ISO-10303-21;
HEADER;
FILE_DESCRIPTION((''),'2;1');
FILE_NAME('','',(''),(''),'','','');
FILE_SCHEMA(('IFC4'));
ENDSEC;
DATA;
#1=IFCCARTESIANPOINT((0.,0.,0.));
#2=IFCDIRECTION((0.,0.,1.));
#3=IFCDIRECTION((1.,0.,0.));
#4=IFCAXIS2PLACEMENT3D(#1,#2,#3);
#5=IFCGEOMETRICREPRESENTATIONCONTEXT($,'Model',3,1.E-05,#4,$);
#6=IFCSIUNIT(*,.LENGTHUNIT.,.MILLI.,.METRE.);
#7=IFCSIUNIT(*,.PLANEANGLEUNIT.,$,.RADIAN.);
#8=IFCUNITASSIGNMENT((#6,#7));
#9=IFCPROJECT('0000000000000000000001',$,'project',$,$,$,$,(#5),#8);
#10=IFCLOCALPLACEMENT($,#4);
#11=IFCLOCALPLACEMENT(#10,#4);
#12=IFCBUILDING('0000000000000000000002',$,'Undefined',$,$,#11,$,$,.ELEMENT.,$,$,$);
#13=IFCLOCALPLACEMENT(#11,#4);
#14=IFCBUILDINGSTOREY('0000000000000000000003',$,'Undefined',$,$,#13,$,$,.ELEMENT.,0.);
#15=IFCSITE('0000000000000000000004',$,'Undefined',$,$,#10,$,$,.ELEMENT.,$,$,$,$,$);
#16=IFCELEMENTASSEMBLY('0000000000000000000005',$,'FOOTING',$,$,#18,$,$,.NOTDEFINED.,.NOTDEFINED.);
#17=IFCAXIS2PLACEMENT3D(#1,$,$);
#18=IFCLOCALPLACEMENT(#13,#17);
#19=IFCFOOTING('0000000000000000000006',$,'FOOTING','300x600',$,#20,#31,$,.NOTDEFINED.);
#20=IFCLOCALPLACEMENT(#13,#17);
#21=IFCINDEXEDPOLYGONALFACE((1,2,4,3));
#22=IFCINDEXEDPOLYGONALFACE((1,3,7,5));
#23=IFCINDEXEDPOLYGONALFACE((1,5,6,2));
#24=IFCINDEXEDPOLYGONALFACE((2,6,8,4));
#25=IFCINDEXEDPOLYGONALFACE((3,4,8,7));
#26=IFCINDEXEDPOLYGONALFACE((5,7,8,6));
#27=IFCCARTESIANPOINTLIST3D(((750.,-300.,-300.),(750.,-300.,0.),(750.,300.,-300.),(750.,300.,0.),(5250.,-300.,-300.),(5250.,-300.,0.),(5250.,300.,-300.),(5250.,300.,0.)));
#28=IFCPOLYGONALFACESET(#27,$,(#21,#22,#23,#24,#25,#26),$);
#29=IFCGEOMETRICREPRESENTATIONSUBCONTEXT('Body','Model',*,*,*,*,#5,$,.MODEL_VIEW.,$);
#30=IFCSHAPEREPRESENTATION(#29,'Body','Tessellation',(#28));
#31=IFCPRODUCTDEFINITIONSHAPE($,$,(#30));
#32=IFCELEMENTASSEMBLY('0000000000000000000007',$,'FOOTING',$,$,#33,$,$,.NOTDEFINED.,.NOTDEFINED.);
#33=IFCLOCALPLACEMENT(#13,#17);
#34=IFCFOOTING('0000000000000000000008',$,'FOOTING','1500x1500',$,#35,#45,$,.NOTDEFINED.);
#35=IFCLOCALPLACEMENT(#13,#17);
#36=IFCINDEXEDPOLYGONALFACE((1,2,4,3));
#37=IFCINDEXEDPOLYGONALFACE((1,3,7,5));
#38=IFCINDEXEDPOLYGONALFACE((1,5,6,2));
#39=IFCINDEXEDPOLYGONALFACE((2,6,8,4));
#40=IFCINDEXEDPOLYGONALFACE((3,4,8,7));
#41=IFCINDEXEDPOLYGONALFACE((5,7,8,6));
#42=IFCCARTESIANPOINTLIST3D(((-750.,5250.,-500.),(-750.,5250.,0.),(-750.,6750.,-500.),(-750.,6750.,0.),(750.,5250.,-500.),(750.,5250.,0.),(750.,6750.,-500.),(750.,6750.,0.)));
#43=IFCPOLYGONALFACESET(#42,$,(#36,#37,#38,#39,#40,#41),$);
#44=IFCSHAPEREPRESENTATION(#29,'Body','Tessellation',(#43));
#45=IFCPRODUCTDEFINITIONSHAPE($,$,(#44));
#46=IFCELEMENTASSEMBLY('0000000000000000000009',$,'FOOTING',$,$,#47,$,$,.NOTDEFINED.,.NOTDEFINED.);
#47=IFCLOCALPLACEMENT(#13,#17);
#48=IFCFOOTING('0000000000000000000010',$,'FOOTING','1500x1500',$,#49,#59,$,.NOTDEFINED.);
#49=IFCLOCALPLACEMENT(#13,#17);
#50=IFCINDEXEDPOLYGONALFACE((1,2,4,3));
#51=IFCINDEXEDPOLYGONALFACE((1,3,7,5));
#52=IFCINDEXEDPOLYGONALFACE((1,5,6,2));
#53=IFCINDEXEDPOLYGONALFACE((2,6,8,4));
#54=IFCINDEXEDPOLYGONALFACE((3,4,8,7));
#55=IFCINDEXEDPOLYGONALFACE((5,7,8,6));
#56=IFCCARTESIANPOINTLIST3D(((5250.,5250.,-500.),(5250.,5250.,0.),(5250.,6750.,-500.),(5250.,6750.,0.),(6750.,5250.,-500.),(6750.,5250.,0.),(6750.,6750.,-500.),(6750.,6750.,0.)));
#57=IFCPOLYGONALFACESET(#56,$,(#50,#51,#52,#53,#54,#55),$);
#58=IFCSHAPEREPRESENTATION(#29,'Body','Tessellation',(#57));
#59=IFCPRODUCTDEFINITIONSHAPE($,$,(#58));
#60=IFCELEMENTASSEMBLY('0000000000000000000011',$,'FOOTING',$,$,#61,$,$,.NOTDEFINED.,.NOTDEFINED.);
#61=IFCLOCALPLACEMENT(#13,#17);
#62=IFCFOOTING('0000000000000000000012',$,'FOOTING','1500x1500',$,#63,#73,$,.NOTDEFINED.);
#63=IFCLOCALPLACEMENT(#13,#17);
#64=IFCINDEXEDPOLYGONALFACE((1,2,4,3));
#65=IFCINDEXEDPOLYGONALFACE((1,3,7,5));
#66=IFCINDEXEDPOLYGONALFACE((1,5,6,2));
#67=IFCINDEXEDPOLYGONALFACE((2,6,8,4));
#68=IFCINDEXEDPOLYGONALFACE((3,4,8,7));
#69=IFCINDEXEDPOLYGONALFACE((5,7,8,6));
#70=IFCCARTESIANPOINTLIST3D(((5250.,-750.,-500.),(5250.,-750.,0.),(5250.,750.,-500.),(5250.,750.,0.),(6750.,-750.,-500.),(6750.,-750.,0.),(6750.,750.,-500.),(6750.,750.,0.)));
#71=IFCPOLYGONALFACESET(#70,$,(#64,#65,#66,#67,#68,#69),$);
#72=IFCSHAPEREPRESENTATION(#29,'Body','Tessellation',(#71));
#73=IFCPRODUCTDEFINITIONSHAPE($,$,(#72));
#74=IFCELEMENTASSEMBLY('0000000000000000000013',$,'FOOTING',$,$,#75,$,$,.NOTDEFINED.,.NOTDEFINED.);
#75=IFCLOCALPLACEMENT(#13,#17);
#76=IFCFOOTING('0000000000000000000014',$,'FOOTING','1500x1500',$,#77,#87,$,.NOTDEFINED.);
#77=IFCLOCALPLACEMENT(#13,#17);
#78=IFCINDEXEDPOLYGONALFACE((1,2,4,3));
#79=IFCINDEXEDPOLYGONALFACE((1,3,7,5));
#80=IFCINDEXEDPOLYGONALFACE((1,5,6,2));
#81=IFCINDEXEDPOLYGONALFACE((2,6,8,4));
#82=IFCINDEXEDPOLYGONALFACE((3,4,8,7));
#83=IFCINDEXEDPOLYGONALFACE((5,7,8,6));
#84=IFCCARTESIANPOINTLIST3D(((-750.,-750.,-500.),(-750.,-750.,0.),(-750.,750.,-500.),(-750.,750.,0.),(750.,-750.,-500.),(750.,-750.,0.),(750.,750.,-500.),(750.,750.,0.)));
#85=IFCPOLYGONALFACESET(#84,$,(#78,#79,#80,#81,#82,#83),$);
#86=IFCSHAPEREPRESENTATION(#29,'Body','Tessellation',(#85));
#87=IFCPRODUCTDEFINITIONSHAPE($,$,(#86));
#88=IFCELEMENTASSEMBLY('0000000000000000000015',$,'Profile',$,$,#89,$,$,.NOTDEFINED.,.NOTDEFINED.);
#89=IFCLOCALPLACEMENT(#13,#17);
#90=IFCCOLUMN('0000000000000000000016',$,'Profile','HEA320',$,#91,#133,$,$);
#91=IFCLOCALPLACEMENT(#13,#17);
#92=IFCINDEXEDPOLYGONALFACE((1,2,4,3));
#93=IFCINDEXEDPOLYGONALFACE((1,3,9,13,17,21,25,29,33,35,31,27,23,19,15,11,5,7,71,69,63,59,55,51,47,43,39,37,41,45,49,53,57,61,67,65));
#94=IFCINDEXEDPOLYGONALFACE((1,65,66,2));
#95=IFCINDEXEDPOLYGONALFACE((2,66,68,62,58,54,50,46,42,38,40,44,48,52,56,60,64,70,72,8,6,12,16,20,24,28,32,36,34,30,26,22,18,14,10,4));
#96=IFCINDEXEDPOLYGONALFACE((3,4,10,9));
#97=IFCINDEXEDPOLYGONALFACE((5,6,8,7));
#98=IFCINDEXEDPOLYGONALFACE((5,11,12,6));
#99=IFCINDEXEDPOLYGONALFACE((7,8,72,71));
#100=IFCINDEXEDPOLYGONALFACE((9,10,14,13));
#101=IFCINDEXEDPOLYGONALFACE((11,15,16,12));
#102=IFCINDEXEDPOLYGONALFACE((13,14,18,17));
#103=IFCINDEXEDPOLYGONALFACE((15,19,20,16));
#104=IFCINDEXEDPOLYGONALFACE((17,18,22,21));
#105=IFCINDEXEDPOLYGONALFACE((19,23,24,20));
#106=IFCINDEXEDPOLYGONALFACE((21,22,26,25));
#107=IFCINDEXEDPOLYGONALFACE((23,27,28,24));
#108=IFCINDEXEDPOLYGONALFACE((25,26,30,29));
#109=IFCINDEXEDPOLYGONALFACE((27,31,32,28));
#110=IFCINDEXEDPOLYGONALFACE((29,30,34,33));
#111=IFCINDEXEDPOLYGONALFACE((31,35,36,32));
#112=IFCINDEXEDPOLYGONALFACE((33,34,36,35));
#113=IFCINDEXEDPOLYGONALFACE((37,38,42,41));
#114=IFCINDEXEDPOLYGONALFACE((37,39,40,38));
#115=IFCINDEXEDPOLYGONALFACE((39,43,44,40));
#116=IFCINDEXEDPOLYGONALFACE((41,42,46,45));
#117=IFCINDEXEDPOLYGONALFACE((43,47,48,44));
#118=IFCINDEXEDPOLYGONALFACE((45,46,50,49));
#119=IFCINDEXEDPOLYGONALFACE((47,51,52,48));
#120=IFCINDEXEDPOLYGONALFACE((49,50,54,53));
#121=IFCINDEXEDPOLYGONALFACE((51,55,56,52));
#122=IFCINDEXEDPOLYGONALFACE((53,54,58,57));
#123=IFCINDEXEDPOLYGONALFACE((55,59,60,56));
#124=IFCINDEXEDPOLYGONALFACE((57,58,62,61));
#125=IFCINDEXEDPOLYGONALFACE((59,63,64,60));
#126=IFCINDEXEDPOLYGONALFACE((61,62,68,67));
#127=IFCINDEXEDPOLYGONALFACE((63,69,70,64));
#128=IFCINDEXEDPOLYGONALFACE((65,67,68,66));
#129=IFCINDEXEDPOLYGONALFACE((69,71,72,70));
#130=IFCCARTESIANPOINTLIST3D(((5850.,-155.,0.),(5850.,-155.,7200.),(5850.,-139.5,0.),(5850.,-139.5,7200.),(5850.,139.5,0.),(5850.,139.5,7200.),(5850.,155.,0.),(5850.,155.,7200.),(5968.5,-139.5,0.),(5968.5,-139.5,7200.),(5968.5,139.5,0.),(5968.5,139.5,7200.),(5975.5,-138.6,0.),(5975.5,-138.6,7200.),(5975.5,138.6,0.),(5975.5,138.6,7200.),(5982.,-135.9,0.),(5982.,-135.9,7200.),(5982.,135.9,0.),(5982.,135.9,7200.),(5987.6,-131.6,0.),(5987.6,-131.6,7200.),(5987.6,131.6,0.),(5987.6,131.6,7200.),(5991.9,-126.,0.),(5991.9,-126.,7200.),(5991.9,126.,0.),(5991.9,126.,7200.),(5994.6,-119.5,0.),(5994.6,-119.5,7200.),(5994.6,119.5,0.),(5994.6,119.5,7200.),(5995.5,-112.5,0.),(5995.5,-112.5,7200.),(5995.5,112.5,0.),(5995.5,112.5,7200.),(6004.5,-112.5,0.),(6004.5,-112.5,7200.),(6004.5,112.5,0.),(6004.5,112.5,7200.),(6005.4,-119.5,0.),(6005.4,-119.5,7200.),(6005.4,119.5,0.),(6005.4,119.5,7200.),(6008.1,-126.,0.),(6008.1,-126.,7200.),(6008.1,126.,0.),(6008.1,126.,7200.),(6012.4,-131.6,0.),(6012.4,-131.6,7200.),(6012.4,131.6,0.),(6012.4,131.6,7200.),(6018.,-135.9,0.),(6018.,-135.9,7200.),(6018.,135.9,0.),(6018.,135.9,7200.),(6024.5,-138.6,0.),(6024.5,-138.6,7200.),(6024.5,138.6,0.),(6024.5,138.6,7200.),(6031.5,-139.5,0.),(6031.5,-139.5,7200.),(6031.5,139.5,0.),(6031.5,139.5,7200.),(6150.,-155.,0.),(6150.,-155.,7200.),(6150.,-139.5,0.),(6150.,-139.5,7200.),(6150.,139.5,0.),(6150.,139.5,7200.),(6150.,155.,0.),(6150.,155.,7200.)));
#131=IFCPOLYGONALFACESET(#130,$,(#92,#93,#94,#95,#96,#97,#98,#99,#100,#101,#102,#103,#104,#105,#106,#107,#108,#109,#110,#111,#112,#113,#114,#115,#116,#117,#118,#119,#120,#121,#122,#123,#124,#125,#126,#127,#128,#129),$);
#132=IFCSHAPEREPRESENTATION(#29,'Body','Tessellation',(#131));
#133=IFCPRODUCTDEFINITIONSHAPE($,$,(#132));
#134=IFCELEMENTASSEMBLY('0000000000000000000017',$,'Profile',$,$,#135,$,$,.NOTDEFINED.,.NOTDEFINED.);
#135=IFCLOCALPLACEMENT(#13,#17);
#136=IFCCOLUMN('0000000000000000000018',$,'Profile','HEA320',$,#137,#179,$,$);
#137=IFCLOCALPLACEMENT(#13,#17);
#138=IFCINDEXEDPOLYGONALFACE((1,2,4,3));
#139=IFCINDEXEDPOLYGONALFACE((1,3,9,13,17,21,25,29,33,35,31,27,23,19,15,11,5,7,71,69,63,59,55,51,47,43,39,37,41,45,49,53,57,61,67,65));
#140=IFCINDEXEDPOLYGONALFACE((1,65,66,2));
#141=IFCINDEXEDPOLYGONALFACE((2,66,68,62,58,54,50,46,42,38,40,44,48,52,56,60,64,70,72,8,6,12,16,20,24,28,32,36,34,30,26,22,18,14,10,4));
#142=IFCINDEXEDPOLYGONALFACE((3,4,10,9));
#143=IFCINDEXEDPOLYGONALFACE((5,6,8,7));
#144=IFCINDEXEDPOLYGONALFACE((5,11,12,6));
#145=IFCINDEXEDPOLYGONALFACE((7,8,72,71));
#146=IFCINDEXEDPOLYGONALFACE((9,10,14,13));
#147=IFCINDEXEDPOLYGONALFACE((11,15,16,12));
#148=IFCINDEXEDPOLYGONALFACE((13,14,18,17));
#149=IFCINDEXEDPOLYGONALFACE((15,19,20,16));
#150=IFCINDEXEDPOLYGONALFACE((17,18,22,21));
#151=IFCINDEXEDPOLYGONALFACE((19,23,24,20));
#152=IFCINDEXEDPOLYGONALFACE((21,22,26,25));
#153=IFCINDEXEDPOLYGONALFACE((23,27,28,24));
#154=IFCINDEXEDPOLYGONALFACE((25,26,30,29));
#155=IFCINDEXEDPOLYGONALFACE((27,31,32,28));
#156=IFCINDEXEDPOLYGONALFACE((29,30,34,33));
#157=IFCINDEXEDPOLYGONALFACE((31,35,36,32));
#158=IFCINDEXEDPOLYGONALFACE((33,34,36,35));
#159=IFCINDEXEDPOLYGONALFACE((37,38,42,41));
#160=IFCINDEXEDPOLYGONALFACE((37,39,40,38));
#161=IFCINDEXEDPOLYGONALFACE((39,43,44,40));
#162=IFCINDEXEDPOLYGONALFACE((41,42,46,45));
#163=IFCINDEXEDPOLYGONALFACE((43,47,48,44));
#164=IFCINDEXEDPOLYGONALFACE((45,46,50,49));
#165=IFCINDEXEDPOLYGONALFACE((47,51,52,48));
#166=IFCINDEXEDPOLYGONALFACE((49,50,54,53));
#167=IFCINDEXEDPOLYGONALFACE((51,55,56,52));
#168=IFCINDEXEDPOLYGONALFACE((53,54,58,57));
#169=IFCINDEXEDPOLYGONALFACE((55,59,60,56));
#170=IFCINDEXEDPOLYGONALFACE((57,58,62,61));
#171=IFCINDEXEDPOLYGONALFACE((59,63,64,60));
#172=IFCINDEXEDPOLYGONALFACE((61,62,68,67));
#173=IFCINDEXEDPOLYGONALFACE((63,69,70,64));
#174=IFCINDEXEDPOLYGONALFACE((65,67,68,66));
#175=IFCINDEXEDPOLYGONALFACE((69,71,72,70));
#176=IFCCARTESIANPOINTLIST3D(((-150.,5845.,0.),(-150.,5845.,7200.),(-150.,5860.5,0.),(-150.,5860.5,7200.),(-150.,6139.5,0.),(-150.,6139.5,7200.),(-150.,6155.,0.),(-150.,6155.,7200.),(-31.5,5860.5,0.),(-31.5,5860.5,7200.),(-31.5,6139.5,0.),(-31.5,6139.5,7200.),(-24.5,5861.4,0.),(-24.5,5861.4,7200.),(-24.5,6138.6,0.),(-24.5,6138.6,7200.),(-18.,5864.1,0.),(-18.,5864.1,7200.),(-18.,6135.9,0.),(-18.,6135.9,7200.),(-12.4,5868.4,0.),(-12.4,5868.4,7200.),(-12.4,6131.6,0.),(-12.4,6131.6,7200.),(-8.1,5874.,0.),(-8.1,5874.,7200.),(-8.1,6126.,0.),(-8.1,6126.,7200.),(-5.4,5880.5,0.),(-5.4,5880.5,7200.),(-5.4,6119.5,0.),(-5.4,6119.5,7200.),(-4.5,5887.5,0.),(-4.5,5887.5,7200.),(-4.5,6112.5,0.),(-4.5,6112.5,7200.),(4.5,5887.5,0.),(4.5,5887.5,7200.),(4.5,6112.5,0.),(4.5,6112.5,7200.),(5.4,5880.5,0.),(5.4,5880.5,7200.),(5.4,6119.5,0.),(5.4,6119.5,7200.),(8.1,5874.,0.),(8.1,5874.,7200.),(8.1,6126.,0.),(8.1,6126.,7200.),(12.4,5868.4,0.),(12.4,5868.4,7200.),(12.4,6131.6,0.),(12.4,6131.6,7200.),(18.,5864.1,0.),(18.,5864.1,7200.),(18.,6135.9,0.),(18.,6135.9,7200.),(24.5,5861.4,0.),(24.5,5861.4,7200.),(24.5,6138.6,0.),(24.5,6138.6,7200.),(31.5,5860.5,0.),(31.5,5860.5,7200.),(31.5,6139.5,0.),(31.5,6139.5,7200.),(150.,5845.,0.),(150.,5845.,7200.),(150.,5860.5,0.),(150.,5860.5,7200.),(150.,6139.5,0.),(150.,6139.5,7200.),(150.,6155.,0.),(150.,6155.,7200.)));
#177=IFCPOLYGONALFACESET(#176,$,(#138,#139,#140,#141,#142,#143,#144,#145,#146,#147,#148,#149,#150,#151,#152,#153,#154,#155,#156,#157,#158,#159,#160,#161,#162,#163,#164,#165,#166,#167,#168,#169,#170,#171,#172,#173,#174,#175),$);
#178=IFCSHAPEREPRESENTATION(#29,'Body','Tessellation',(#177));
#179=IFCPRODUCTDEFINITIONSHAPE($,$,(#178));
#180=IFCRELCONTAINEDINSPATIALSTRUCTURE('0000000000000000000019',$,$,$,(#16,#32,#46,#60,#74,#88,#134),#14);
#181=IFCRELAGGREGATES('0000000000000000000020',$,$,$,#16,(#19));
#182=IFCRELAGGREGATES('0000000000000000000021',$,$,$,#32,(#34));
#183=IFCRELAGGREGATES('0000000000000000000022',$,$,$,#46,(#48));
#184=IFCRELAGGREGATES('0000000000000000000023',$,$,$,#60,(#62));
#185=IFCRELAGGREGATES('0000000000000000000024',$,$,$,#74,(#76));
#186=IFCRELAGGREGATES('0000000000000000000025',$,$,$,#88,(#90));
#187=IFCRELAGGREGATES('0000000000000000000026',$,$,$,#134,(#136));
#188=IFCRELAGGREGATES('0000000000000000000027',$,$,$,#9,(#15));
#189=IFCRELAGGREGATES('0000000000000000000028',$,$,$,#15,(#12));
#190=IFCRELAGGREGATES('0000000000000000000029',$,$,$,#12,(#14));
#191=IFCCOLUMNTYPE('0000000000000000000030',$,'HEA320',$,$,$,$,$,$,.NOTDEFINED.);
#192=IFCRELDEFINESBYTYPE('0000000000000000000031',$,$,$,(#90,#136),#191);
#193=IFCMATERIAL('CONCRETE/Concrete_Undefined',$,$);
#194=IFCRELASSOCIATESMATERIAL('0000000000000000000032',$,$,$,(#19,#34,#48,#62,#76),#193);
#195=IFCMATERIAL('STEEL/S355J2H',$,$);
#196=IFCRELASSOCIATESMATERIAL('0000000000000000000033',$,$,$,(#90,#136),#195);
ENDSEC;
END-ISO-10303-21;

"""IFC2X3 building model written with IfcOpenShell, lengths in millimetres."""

from ifc_helpers import new_model, si_unit, frame, origin_with_axes, origin_2d_with_axis, place, context, subcontext, project, spatial, rectangle, i_section, extrude, material, type_object, element, aggregate, save


model = new_model("IFC2X3")

# Units and contexts
model_context = context("Model", 3, precision=1e-05, world=origin_with_axes())
body_context = subcontext(model_context, "Body", "Model", "MODEL_VIEW")
ifc_project = project(units=[si_unit("LENGTHUNIT", "METRE", prefix="MILLI"), si_unit("PLANEANGLEUNIT", "RADIAN")], contexts=[model_context])

# Site, building, storey
site_placement = place(None, origin_with_axes())
site = spatial("IfcSite", under=ifc_project, at=site_placement, Name="Undefined", CompositionType="ELEMENT")
building_placement = place(site_placement, origin_with_axes())
building = spatial("IfcBuilding", under=site, at=building_placement, Name="Undefined", CompositionType="ELEMENT")
storey_placement = place(building_placement, origin_with_axes())
storey = spatial("IfcBuildingStorey", under=building, at=storey_placement, Name="Undefined", CompositionType="ELEMENT", Elevation=0.0)

# Element assemblies, footings
assembly_1_placement = place(storey_placement, origin_with_axes())
assembly_1 = element("IfcElementAssembly", 1, at=assembly_1_placement, inside=storey, Name="FOOTING", AssemblyPlace="NOTDEFINED", PredefinedType="NOTDEFINED")
ifc_material_1 = material(Name="CONCRETE/Concrete_Undefined")
footing_1_placement = place(assembly_1_placement, frame((750.0, 0.0, -150.0), z_axis=(0.0, 0.0, 1.0), x_axis=(1.0, 0.0, 0.0)))
footing_1 = element("IfcFooting", 2, at=footing_1_placement, material=ifc_material_1, Name="FOOTING", Description="300x600", PredefinedType="NOTDEFINED", context=body_context, shape_type="SweptSolid", body=[
    extrude(rectangle(XDim=600.0, YDim=300.0, at=origin_2d_with_axis()), frame((4500.0, 0.0, 0.0), z_axis=(-1.0, 0.0, 0.0), x_axis=(0.0, -1.0, 0.0)), (0.0, 0.0, 1.0), 4500.0),
])
aggregate(assembly_1, [footing_1])
assembly_2_placement = place(storey_placement, origin_with_axes())
assembly_2 = element("IfcElementAssembly", 3, at=assembly_2_placement, inside=storey, Name="FOOTING", AssemblyPlace="NOTDEFINED", PredefinedType="NOTDEFINED")
footing_2_placement = place(assembly_2_placement, frame((0.0, 6000.0, -500.0), z_axis=(0.0, 1.0, 0.0), x_axis=(0.0, 0.0, 1.0)))
footing_2 = element("IfcFooting", 4, at=footing_2_placement, material=ifc_material_1, Name="FOOTING", Description="1500x1500", PredefinedType="NOTDEFINED", context=body_context, shape_type="SweptSolid", body=[
    extrude(rectangle(XDim=1500.0, YDim=1500.0, at=origin_2d_with_axis()), frame((500.0, 0.0, 0.0), z_axis=(-1.0, 0.0, 0.0), x_axis=(0.0, -1.0, 0.0)), (0.0, 0.0, 1.0), 500.0),
])
aggregate(assembly_2, [footing_2])
assembly_3_placement = place(storey_placement, origin_with_axes())
assembly_3 = element("IfcElementAssembly", 5, at=assembly_3_placement, inside=storey, Name="FOOTING", AssemblyPlace="NOTDEFINED", PredefinedType="NOTDEFINED")
footing_3_placement = place(assembly_3_placement, frame((6000.0, 6000.0, -500.0), z_axis=(0.0, 1.0, 0.0), x_axis=(0.0, 0.0, 1.0)))
footing_3 = element("IfcFooting", 6, at=footing_3_placement, material=ifc_material_1, Name="FOOTING", Description="1500x1500", PredefinedType="NOTDEFINED", context=body_context, shape_type="SweptSolid", body=[
    extrude(rectangle(XDim=1500.0, YDim=1500.0, at=origin_2d_with_axis()), frame((500.0, 0.0, 0.0), z_axis=(-1.0, 0.0, 0.0), x_axis=(0.0, -1.0, 0.0)), (0.0, 0.0, 1.0), 500.0),
])
aggregate(assembly_3, [footing_3])
assembly_4_placement = place(storey_placement, origin_with_axes())
assembly_4 = element("IfcElementAssembly", 7, at=assembly_4_placement, inside=storey, Name="FOOTING", AssemblyPlace="NOTDEFINED", PredefinedType="NOTDEFINED")
footing_4_placement = place(assembly_4_placement, frame((6000.0, 0.0, -500.0), z_axis=(0.0, 1.0, 0.0), x_axis=(0.0, 0.0, 1.0)))
footing_4 = element("IfcFooting", 8, at=footing_4_placement, material=ifc_material_1, Name="FOOTING", Description="1500x1500", PredefinedType="NOTDEFINED", context=body_context, shape_type="SweptSolid", body=[
    extrude(rectangle(XDim=1500.0, YDim=1500.0, at=origin_2d_with_axis()), frame((500.0, 0.0, 0.0), z_axis=(-1.0, 0.0, 0.0), x_axis=(0.0, -1.0, 0.0)), (0.0, 0.0, 1.0), 500.0),
])
aggregate(assembly_4, [footing_4])
assembly_5_placement = place(storey_placement, origin_with_axes())
assembly_5 = element("IfcElementAssembly", 9, at=assembly_5_placement, inside=storey, Name="FOOTING", AssemblyPlace="NOTDEFINED", PredefinedType="NOTDEFINED")
footing_5_placement = place(assembly_5_placement, frame((0.0, 0.0, -500.0), z_axis=(0.0, 1.0, 0.0), x_axis=(0.0, 0.0, 1.0)))
footing_5 = element("IfcFooting", 10, at=footing_5_placement, material=ifc_material_1, Name="FOOTING", Description="1500x1500", PredefinedType="NOTDEFINED", context=body_context, shape_type="SweptSolid", body=[
    extrude(rectangle(XDim=1500.0, YDim=1500.0, at=origin_2d_with_axis()), frame((500.0, 0.0, 0.0), z_axis=(-1.0, 0.0, 0.0), x_axis=(0.0, -1.0, 0.0)), (0.0, 0.0, 1.0), 500.0),
])
aggregate(assembly_5, [footing_5])

# Element assemblies, columns
assembly_6_placement = place(storey_placement, origin_with_axes())
assembly_6 = element("IfcElementAssembly", 11, at=assembly_6_placement, inside=storey, Name="Profile", AssemblyPlace="NOTDEFINED", PredefinedType="NOTDEFINED")
ifc_material_2 = material(Name="STEEL/S355J2H")
column_type = type_object("IfcColumnType", Name="HEA320", PredefinedType="NOTDEFINED")
column_1_placement = place(assembly_6_placement, frame((6000.0, 0.0, 0.0), z_axis=(0.0, 0.0, 1.0), x_axis=(0.0, 1.0, 0.0)))
column_1 = element("IfcColumn", 12, at=column_1_placement, type_object=column_type, material=ifc_material_2, Name="Profile", Description="HEA320", context=body_context, shape_type="SweptSolid", body=[
    extrude(i_section(OverallWidth=300.0, OverallDepth=310.0, WebThickness=9.0, FlangeThickness=15.5, FilletRadius=27.0, at=origin_2d_with_axis()), frame((0.0, 0.0, 7200.0), z_axis=(0.0, 0.0, -1.0), x_axis=(0.0, 1.0, 0.0)), (0.0, 0.0, 1.0), 7200.0),
])
aggregate(assembly_6, [column_1])
assembly_7_placement = place(storey_placement, origin_with_axes())
assembly_7 = element("IfcElementAssembly", 13, at=assembly_7_placement, inside=storey, Name="Profile", AssemblyPlace="NOTDEFINED", PredefinedType="NOTDEFINED")
column_2_placement = place(assembly_7_placement, frame((0.0, 6000.0, 0.0), z_axis=(0.0, 0.0, 1.0), x_axis=(0.0, 1.0, 0.0)))
column_2 = element("IfcColumn", 14, at=column_2_placement, type_object=column_type, material=ifc_material_2, Name="Profile", Description="HEA320", context=body_context, shape_type="SweptSolid", body=[
    extrude(i_section(OverallWidth=300.0, OverallDepth=310.0, WebThickness=9.0, FlangeThickness=15.5, FilletRadius=27.0, at=origin_2d_with_axis()), frame((0.0, 0.0, 7200.0), z_axis=(0.0, 0.0, -1.0), x_axis=(0.0, 1.0, 0.0)), (0.0, 0.0, 1.0), 7200.0),
])
aggregate(assembly_7, [column_2])

save(model, "model.ifc")
